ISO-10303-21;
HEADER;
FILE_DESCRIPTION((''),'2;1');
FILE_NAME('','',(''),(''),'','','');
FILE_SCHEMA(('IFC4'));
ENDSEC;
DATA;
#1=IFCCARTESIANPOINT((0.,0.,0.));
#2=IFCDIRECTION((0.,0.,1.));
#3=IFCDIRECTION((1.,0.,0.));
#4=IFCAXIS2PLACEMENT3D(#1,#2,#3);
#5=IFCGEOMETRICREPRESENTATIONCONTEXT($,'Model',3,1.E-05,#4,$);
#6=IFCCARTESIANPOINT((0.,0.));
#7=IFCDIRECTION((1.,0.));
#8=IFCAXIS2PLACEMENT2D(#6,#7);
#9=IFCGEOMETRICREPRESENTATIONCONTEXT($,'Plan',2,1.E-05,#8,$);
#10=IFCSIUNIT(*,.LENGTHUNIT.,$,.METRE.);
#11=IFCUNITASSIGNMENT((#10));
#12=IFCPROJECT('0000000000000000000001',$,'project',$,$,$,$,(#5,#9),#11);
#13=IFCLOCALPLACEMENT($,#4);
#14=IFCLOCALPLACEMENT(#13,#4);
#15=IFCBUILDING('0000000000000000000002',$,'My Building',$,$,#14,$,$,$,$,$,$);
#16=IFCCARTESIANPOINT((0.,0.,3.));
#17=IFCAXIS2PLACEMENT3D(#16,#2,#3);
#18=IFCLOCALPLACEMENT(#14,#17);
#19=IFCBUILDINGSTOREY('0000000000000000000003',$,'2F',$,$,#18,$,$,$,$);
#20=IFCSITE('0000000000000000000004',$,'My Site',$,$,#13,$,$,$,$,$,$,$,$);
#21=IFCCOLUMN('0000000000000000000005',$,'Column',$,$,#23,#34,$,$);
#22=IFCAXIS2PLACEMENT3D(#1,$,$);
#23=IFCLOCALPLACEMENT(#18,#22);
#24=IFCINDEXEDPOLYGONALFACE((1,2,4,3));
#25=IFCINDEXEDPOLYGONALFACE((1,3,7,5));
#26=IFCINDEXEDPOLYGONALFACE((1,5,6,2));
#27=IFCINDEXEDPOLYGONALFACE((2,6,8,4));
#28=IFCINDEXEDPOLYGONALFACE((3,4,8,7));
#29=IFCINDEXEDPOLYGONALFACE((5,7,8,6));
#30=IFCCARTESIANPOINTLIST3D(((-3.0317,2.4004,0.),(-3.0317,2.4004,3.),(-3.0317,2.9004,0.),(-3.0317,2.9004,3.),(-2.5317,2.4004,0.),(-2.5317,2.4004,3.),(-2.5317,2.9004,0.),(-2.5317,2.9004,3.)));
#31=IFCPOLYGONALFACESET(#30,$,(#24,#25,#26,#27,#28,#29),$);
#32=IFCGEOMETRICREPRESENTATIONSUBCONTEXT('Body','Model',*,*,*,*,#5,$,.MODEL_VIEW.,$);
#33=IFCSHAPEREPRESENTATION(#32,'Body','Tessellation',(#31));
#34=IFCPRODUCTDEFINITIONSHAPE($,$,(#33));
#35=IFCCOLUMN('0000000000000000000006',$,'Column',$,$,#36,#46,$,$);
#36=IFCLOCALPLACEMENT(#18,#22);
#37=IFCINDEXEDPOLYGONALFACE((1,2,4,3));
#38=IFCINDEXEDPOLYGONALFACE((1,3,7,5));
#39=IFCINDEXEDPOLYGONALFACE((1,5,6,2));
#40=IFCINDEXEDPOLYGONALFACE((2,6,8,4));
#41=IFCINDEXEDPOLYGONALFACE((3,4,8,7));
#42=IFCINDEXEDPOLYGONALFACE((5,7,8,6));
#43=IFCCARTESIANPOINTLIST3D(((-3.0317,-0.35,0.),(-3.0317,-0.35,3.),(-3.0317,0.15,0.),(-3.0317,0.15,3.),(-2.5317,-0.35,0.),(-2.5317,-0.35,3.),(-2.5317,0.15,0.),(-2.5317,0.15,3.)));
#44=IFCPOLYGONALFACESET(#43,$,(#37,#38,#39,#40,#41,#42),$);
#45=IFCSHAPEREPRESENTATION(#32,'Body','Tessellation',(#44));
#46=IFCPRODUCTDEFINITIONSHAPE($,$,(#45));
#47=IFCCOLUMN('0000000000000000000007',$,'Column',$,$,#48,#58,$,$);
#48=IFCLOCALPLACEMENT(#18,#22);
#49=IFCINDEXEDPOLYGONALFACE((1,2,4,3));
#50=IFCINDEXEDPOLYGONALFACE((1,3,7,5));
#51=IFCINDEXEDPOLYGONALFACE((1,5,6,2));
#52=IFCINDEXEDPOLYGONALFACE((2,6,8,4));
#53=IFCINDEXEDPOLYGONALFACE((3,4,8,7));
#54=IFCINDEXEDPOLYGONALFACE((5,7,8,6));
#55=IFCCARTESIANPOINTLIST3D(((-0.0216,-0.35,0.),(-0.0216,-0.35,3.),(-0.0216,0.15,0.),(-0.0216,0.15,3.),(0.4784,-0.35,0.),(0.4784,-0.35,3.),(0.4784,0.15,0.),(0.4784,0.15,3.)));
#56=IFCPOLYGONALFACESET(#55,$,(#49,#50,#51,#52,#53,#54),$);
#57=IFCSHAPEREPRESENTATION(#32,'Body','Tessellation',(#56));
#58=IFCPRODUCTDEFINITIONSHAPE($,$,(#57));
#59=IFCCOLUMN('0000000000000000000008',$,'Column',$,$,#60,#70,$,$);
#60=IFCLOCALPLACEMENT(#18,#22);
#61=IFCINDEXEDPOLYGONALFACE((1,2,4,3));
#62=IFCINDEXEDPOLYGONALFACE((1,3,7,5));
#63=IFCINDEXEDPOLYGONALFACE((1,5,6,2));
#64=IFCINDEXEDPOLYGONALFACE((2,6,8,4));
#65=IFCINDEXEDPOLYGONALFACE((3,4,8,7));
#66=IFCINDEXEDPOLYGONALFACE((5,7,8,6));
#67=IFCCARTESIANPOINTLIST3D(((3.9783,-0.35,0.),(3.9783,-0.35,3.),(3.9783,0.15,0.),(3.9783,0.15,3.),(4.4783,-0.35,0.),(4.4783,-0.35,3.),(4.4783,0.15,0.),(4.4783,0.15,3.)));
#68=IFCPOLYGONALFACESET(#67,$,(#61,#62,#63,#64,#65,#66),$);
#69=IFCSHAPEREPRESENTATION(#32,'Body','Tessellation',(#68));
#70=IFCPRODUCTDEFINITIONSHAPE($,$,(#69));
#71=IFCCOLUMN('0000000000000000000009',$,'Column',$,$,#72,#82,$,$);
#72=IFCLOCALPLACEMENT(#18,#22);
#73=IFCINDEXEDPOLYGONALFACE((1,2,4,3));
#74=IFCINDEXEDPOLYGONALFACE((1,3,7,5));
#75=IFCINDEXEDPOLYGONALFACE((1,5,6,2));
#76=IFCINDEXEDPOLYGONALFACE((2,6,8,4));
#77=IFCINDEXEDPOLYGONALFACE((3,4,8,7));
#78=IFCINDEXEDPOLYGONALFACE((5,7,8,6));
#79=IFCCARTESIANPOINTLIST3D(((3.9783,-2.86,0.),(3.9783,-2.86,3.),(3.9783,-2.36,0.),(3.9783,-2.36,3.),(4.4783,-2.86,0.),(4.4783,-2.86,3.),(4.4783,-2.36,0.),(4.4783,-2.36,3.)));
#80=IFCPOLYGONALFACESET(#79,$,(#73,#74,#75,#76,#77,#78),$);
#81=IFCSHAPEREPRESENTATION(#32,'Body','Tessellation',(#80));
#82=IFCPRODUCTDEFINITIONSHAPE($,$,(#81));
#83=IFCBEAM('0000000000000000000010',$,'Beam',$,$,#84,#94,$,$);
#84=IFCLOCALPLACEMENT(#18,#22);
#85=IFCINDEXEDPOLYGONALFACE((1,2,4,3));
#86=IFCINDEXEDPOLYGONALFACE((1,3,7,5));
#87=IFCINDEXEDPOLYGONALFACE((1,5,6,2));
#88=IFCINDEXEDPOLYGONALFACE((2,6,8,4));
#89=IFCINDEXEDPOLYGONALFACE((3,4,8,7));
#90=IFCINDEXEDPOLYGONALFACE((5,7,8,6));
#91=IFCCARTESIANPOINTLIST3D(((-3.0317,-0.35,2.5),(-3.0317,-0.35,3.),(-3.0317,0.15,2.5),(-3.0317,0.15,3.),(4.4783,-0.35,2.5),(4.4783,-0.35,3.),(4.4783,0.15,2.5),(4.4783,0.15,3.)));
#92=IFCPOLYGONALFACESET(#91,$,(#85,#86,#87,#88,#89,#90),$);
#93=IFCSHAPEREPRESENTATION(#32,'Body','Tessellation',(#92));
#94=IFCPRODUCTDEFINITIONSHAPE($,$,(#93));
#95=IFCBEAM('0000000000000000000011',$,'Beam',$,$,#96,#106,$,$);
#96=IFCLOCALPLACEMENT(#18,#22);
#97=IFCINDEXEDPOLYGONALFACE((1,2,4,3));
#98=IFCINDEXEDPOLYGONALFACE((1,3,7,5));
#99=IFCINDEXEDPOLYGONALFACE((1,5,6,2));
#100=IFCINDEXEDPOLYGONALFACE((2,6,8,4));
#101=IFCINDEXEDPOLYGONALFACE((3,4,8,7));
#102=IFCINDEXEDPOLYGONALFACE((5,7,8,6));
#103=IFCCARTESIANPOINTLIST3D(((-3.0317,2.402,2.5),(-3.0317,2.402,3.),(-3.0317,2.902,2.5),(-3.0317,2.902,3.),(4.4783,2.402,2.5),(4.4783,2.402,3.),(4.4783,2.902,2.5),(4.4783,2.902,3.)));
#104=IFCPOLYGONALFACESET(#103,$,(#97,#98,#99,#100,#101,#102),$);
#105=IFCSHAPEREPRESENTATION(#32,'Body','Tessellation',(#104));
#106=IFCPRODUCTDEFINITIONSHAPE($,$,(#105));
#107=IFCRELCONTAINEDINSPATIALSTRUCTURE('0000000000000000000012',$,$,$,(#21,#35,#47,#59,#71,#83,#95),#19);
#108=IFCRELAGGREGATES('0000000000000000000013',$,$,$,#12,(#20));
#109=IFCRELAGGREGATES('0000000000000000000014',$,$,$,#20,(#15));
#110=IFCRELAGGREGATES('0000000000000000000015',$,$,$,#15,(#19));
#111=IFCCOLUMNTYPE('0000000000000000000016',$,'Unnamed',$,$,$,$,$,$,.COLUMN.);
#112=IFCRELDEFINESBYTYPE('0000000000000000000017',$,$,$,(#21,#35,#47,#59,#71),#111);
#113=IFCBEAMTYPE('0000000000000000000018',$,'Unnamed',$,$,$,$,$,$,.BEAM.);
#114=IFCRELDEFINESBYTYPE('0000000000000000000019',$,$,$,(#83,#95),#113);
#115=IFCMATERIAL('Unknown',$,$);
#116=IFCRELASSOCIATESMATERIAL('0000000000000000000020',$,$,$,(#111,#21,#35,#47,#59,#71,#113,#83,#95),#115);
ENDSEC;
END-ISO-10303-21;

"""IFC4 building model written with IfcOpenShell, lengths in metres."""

from ifc_helpers import new_model, si_unit, frame, origin_with_axes, origin_2d_with_axis, place, context, subcontext, project, spatial, rectangle, extrude, material, material_profile, profile_set, profile_usage, type_object, element, save


model = new_model("IFC4")

# Units and contexts
model_context = context("Model", 3, precision=1e-05, world=origin_with_axes())
plan_context = context("Plan", 2, precision=1e-05, world=origin_2d_with_axis())
body_context_1 = subcontext(model_context, "Body", "Model", "MODEL_VIEW")
ifc_project = project(units=[si_unit("LENGTHUNIT", "METRE")], contexts=[model_context, plan_context])

# Site, building, storey
site_placement = place(None, origin_with_axes())
site = spatial("IfcSite", under=ifc_project, at=site_placement, Name="My Site")
building_placement = place(site_placement, origin_with_axes())
building = spatial("IfcBuilding", under=site, at=building_placement, Name="My Building")
storey_placement = place(building_placement, frame((0.0, 0.0, 3.0), z_axis=(0.0, 0.0, 1.0), x_axis=(1.0, 0.0, 0.0)))
storey = spatial("IfcBuildingStorey", under=building, at=storey_placement, Name="2F")

# Columns
ifc_material = material(Name="Unknown")
ifc_material_profile_1 = material_profile(ifc_material, rectangle(XDim=0.5, YDim=0.5))
ifc_profile_set_1 = profile_set([ifc_material_profile_1])
ifc_profile_usage_1 = profile_usage(ifc_profile_set_1, cardinal=7)
column_type = type_object("IfcColumnType", Name="Unnamed", PredefinedType="COLUMN", material=ifc_profile_set_1)
column_1_placement = place(storey_placement, frame((-2.5317, 2.9004, 0.0), z_axis=(0.0, 0.0, 1.0), x_axis=(1.0, 0.0, 0.0)))
element("IfcColumn", 1, at=column_1_placement, inside=storey, type_object=column_type, material=ifc_profile_usage_1, Name="Column", context=body_context_1, shape_type="SweptSolid", body=[
    extrude(rectangle(XDim=0.5, YDim=0.5), frame((-0.25, -0.25, 0.0), z_axis=(0.0, 0.0, 1.0), x_axis=(1.0, 0.0, 0.0)), (0.0, 0.0, 1.0), 3.0),
])
ifc_profile_usage_2 = profile_usage(ifc_profile_set_1, cardinal=7)
column_2_placement = place(storey_placement, frame((-2.5317, 0.15, 0.0), z_axis=(0.0, 0.0, 1.0), x_axis=(1.0, 0.0, 0.0)))
element("IfcColumn", 2, at=column_2_placement, inside=storey, type_object=column_type, material=ifc_profile_usage_2, Name="Column", context=body_context_1, shape_type="SweptSolid", body=[
    extrude(rectangle(XDim=0.5, YDim=0.5), frame((-0.25, -0.25, 0.0), z_axis=(0.0, 0.0, 1.0), x_axis=(1.0, 0.0, 0.0)), (0.0, 0.0, 1.0), 3.0),
])
ifc_profile_usage_3 = profile_usage(ifc_profile_set_1, cardinal=7)
column_3_placement = place(storey_placement, frame((0.4784, 0.15, 0.0), z_axis=(0.0, 0.0, 1.0), x_axis=(1.0, 0.0, 0.0)))
element("IfcColumn", 3, at=column_3_placement, inside=storey, type_object=column_type, material=ifc_profile_usage_3, Name="Column", context=body_context_1, shape_type="SweptSolid", body=[
    extrude(rectangle(XDim=0.5, YDim=0.5), frame((-0.25, -0.25, 0.0), z_axis=(0.0, 0.0, 1.0), x_axis=(1.0, 0.0, 0.0)), (0.0, 0.0, 1.0), 3.0),
])
ifc_profile_usage_4 = profile_usage(ifc_profile_set_1, cardinal=7)
column_4_placement = place(storey_placement, frame((4.4783, 0.15, 0.0), z_axis=(0.0, 0.0, 1.0), x_axis=(1.0, 0.0, 0.0)))
element("IfcColumn", 4, at=column_4_placement, inside=storey, type_object=column_type, material=ifc_profile_usage_4, Name="Column", context=body_context_1, shape_type="SweptSolid", body=[
    extrude(rectangle(XDim=0.5, YDim=0.5), frame((-0.25, -0.25, 0.0), z_axis=(0.0, 0.0, 1.0), x_axis=(1.0, 0.0, 0.0)), (0.0, 0.0, 1.0), 3.0),
])
ifc_profile_usage_5 = profile_usage(ifc_profile_set_1, cardinal=7)
column_5_placement = place(storey_placement, frame((4.4783, -2.36, 0.0), z_axis=(0.0, 0.0, 1.0), x_axis=(1.0, 0.0, 0.0)))
element("IfcColumn", 5, at=column_5_placement, inside=storey, type_object=column_type, material=ifc_profile_usage_5, Name="Column", context=body_context_1, shape_type="SweptSolid", body=[
    extrude(rectangle(XDim=0.5, YDim=0.5), frame((-0.25, -0.25, 0.0), z_axis=(0.0, 0.0, 1.0), x_axis=(1.0, 0.0, 0.0)), (0.0, 0.0, 1.0), 3.0),
])

# Beams
ifc_material_profile_2 = material_profile(ifc_material, rectangle(XDim=0.5, YDim=0.5))
ifc_profile_set_2 = profile_set([ifc_material_profile_2])
ifc_profile_usage_6 = profile_usage(ifc_profile_set_2, cardinal=7)
beam_type = type_object("IfcBeamType", Name="Unnamed", PredefinedType="BEAM", material=ifc_profile_set_2)
beam_1_placement = place(storey_placement, frame((4.4783, -0.35, 3.0), z_axis=(-1.0, 0.0, 0.0), x_axis=(0.0, -1.0, 0.0)))
element("IfcBeam", 6, at=beam_1_placement, inside=storey, type_object=beam_type, material=ifc_profile_usage_6, Name="Beam", context=body_context_1, shape_type="SweptSolid", body=[
    extrude(rectangle(XDim=0.5, YDim=0.5), frame((-0.25, -0.25, 0.0), z_axis=(0.0, 0.0, 1.0), x_axis=(1.0, 0.0, 0.0)), (0.0, 0.0, 1.0), 7.51),
])
ifc_profile_usage_7 = profile_usage(ifc_profile_set_2, cardinal=7)
beam_2_placement = place(storey_placement, frame((4.4783, 2.402, 3.0), z_axis=(-1.0, 0.0, 0.0), x_axis=(0.0, -1.0, 0.0)))
element("IfcBeam", 7, at=beam_2_placement, inside=storey, type_object=beam_type, material=ifc_profile_usage_7, Name="Beam", context=body_context_1, shape_type="SweptSolid", body=[
    extrude(rectangle(XDim=0.5, YDim=0.5), frame((-0.25, -0.25, 0.0), z_axis=(0.0, 0.0, 1.0), x_axis=(1.0, 0.0, 0.0)), (0.0, 0.0, 1.0), 7.51),
])

save(model, "model.ifc")
